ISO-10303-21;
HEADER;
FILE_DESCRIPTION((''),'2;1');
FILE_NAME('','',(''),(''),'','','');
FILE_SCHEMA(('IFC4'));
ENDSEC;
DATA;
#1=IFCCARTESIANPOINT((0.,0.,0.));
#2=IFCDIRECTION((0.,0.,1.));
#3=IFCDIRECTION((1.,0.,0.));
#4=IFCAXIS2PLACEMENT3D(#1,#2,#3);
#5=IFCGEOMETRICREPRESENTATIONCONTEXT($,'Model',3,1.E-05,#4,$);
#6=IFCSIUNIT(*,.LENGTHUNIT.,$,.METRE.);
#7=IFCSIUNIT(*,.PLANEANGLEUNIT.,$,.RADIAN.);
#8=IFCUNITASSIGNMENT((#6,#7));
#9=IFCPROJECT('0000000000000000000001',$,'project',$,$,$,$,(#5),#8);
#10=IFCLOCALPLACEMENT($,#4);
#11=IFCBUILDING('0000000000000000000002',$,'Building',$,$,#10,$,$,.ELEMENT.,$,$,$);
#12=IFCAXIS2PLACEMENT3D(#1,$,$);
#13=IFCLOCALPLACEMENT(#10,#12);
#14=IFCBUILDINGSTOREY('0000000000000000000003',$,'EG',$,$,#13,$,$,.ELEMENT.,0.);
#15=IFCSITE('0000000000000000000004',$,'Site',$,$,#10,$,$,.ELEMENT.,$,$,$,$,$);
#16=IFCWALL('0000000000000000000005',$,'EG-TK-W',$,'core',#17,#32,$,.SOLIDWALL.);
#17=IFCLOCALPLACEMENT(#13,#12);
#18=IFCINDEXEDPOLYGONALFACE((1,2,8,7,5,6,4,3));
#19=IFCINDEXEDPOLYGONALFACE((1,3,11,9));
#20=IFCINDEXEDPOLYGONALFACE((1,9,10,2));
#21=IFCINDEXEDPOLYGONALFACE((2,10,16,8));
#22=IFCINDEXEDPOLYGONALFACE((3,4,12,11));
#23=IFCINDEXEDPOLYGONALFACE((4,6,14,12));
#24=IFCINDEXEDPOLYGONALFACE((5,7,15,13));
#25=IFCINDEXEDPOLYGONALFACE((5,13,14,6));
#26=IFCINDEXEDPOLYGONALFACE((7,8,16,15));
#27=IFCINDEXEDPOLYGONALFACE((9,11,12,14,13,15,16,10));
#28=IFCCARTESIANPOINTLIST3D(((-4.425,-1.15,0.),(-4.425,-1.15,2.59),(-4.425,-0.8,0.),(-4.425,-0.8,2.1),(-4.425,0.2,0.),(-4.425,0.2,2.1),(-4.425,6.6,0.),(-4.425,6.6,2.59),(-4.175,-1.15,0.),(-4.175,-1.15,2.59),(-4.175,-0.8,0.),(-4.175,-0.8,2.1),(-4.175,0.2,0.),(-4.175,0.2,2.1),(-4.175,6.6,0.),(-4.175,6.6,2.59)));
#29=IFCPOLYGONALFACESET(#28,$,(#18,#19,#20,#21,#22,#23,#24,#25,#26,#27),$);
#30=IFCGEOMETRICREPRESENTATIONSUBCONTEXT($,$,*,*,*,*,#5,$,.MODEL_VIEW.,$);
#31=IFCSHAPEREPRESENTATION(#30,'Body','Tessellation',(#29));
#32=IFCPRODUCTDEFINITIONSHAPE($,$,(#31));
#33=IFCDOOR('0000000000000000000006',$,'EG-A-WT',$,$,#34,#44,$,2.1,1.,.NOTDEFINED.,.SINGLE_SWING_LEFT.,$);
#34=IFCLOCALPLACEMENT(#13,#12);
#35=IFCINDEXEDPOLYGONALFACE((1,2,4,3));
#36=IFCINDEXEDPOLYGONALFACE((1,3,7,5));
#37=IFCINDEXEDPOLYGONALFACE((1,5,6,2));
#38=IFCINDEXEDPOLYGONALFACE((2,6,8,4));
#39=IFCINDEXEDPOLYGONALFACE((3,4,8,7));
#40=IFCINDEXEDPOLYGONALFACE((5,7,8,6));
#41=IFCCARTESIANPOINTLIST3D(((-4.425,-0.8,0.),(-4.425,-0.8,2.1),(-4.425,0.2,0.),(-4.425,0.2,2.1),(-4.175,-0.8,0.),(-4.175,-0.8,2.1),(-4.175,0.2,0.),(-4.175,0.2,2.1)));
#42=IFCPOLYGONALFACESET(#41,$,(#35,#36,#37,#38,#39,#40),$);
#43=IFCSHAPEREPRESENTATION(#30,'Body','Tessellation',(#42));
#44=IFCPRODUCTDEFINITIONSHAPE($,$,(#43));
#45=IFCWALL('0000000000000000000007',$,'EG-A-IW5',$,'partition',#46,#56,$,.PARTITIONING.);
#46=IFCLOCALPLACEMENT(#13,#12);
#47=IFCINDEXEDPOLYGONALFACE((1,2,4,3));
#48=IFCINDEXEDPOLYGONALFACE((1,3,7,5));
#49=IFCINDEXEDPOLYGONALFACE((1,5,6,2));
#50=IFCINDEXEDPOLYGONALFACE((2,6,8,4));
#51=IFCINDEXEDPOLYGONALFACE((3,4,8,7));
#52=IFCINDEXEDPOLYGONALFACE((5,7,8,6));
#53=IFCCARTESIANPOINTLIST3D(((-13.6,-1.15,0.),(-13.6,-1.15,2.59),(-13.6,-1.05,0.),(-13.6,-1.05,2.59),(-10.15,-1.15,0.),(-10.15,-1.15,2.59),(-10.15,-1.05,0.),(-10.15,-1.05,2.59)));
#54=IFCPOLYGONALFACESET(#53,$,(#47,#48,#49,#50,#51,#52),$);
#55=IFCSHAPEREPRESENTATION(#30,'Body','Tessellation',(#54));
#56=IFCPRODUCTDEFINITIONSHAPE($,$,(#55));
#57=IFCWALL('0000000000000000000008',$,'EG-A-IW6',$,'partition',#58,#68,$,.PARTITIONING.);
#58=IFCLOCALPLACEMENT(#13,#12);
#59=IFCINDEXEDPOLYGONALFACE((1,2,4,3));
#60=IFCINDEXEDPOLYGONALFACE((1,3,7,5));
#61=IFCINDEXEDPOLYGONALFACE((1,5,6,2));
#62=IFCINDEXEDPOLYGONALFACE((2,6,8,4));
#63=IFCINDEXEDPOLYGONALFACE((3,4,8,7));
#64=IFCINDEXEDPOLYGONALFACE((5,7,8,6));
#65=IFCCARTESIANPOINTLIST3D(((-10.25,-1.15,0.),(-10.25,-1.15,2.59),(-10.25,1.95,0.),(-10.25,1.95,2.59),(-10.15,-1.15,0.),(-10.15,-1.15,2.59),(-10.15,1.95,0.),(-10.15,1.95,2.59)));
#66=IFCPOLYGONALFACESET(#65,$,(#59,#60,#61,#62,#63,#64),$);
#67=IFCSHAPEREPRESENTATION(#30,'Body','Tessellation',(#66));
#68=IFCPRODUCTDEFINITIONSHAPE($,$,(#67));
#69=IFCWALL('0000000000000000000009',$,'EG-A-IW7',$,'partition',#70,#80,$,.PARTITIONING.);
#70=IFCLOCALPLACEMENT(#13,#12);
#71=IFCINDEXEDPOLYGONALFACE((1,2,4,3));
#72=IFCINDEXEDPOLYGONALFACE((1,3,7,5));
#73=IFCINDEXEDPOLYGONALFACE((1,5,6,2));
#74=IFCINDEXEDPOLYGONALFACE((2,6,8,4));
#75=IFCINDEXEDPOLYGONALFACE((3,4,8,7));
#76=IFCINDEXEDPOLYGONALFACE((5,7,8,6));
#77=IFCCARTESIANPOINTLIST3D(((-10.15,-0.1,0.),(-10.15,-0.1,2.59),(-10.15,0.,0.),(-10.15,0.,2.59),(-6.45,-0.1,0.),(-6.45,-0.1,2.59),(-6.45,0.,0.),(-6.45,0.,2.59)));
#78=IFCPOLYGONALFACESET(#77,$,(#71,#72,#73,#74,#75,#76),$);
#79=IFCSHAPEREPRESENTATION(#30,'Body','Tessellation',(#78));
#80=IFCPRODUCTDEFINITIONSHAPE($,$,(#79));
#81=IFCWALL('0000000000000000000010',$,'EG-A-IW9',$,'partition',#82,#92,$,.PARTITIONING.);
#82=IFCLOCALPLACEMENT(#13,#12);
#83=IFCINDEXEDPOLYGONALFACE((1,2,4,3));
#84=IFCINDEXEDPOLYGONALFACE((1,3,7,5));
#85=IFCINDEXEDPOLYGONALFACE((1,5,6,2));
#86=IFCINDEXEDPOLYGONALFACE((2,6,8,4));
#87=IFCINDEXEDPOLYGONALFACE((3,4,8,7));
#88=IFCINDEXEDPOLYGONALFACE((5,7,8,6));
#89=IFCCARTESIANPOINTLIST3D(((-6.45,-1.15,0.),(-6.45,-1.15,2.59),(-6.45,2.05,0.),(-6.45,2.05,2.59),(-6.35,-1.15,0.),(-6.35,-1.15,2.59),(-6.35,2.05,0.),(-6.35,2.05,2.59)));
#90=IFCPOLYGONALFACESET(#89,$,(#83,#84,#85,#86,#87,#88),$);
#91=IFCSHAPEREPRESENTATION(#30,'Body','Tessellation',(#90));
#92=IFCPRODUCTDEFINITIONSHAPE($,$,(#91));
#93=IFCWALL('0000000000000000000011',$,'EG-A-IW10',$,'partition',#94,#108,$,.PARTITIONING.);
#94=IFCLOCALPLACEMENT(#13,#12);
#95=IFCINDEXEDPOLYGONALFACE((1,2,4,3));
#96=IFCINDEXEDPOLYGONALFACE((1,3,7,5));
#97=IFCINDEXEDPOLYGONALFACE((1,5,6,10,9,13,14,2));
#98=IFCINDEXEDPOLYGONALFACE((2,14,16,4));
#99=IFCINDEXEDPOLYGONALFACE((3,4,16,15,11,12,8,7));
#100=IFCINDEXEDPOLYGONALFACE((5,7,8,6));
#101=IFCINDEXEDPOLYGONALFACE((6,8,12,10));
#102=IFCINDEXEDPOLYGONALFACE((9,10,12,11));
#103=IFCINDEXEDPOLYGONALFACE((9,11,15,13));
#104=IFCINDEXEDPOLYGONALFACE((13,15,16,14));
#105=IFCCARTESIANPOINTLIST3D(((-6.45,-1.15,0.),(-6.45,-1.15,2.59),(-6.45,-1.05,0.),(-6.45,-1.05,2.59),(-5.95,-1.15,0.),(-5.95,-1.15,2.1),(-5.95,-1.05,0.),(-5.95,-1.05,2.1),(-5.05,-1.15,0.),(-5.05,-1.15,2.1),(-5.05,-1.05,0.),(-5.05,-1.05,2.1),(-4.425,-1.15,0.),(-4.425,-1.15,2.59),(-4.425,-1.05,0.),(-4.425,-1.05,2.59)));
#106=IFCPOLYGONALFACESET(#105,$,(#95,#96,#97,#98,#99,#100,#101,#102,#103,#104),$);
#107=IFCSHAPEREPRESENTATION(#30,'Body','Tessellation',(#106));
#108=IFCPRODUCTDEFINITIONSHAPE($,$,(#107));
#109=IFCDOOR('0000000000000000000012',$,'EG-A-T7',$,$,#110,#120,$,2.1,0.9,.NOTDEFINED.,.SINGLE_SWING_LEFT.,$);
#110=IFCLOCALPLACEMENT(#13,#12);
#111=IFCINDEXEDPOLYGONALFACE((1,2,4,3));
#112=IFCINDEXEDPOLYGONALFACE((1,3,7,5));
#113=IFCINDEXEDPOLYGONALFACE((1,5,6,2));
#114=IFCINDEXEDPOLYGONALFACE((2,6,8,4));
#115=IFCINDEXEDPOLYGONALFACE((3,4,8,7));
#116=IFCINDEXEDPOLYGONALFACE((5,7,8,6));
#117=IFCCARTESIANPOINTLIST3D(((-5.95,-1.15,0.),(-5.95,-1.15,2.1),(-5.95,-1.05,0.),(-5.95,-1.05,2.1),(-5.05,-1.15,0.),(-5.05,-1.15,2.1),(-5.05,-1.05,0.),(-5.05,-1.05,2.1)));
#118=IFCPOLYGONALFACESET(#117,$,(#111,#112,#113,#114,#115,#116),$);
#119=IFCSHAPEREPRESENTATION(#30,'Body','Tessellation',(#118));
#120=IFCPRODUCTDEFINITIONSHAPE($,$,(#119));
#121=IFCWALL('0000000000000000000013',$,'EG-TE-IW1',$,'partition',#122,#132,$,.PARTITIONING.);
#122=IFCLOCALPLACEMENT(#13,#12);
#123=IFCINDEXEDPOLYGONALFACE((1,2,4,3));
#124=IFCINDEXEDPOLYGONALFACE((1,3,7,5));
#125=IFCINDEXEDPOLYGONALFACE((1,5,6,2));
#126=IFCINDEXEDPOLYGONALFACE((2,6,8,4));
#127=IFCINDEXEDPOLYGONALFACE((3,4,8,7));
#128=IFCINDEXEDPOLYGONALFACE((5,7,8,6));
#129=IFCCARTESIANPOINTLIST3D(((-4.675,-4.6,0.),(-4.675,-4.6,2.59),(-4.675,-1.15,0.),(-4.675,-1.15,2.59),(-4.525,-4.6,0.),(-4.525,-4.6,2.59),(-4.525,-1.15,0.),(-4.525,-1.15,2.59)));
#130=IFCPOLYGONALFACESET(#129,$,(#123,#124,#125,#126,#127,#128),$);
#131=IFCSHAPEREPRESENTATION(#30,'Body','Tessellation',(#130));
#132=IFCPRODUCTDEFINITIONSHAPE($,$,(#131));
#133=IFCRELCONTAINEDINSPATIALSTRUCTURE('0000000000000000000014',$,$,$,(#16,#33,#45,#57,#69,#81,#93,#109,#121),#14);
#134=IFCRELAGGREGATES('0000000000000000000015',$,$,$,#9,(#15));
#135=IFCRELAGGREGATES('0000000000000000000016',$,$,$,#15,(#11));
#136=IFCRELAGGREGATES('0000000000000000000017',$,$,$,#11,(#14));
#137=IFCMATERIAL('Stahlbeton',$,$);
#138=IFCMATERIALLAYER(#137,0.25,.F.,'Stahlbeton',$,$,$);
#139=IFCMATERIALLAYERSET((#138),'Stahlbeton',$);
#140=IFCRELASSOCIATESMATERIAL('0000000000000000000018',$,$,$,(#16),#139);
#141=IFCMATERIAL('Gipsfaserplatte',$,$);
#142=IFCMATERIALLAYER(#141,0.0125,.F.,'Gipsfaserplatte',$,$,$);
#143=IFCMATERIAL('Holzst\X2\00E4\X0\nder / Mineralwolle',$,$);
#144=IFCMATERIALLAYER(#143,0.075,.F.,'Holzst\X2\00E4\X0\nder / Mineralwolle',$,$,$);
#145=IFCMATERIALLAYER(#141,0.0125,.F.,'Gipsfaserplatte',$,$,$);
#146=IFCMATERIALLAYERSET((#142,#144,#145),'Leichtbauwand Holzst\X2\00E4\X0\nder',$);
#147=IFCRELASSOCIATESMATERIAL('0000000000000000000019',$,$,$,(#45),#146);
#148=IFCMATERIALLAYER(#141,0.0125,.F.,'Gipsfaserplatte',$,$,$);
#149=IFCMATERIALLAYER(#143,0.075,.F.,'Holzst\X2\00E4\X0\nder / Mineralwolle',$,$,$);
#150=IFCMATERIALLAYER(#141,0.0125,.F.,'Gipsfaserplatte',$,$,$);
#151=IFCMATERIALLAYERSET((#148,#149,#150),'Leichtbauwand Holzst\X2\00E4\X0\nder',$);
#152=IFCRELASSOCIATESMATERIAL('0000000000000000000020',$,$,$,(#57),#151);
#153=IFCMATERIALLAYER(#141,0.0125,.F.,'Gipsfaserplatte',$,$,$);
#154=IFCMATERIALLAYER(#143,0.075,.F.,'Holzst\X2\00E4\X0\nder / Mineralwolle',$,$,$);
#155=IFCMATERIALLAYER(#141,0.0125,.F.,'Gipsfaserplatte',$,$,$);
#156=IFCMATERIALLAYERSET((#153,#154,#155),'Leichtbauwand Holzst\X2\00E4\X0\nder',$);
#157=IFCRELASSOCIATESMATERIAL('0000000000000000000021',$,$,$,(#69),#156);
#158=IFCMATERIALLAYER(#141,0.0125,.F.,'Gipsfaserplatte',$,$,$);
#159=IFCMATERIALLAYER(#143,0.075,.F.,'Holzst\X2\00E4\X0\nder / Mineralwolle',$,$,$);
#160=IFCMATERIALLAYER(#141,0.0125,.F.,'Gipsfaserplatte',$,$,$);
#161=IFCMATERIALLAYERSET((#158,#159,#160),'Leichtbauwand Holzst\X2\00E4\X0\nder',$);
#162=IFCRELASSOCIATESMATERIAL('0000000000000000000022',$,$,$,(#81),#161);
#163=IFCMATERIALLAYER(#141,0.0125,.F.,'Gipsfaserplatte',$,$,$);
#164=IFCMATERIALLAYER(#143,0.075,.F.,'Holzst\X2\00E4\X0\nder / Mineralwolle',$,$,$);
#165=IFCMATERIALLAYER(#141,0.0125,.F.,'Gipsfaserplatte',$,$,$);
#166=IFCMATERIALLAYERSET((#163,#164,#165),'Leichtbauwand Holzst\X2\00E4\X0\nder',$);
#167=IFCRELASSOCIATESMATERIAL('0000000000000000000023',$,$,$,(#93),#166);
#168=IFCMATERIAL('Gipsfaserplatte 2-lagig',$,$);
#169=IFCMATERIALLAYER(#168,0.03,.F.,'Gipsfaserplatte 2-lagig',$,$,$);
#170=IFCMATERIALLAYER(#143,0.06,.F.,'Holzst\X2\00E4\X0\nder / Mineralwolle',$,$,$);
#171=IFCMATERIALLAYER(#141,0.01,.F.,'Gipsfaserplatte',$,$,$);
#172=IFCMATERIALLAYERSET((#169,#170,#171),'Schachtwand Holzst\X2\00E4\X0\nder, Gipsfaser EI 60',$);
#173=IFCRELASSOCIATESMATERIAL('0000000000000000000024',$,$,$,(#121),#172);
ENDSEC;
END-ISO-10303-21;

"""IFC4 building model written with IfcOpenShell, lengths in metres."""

from ifc_helpers import new_model, si_unit, frame, frame_2d, origin, origin_with_axes, place, context, subcontext, project, spatial, rectangle, extrude, material, layer, layer_set, element, fill, save


model = new_model("IFC4")

# Units and contexts
model_context = context("Model", 3, precision=1e-05, world=origin_with_axes())
sub_context = subcontext(model_context, None, None, "MODEL_VIEW")
ifc_project = project(units=[si_unit("LENGTHUNIT", "METRE"), si_unit("PLANEANGLEUNIT", "RADIAN")], contexts=[model_context])

# Site, building, storey
placement = place(None, origin_with_axes())
site = spatial("IfcSite", under=ifc_project, at=placement, Name="Site", CompositionType="ELEMENT")
building = spatial("IfcBuilding", under=site, at=placement, Name="Building", CompositionType="ELEMENT")
storey_placement = place(placement, origin())
storey = spatial("IfcBuildingStorey", under=building, at=storey_placement, Name="EG", CompositionType="ELEMENT", Elevation=0.0)

# Shared definitions
ifc_material_1 = material(Name="Gipsfaserplatte")

# Wall, opening, door
ifc_material_2 = material(Name="Stahlbeton")
ifc_layer_1 = layer(ifc_material_2, 0.25, ventilated=False, Name="Stahlbeton")
ifc_layer_set_1 = layer_set([ifc_layer_1], Name="Stahlbeton")
wall_1_placement = place(storey_placement, frame((-4.3, -1.15, 0.0), z_axis=(0.0, 0.0, 1.0), x_axis=(0.0, 1.0, 0.0)))
wall_1 = element("IfcWall", 1, at=wall_1_placement, inside=storey, material=ifc_layer_set_1, Name="EG-TK-W", ObjectType="core", PredefinedType="SOLIDWALL", context=sub_context, shape_type="SweptSolid", body=[
    extrude(rectangle(XDim=7.75, YDim=0.25, at=frame_2d((3.875, 0.0))), origin(), (0.0, 0.0, 1.0), 2.59),
])
opening_1_placement = place(wall_1_placement, frame((0.85, 0.175, 0.0), z_axis=(0.0, -1.0, 0.0), x_axis=(1.0, 0.0, 0.0)))
opening_1 = element("IfcOpeningElement", 2, at=opening_1_placement, cuts=wall_1, PredefinedType="OPENING", context=sub_context, shape_type="SweptSolid", body=[
    extrude(rectangle(XDim=1.0, YDim=2.1, at=frame_2d((0.0, 1.05))), origin(), (0.0, 0.0, 1.0), 0.35),
])
door_1_placement = place(wall_1_placement, frame((0.85, 0.125, 0.0), z_axis=(0.0, -1.0, 0.0), x_axis=(1.0, 0.0, 0.0)))
door_1 = element("IfcDoor", 3, at=door_1_placement, inside=storey, Name="EG-A-WT", OperationType="SINGLE_SWING_LEFT", OverallHeight=2.1, OverallWidth=1.0, PredefinedType="NOTDEFINED", context=sub_context, shape_type="SweptSolid", body=[
    extrude(rectangle(XDim=1.0, YDim=2.1, at=frame_2d((0.0, 1.05))), origin(), (0.0, 0.0, 1.0), 0.25),
])
fill(opening_1, door_1)

# Walls
ifc_layer_2 = layer(ifc_material_1, 0.0125, ventilated=False, Name="Gipsfaserplatte")
ifc_material_3 = material(Name="Holzständer / Mineralwolle")
ifc_layer_3 = layer(ifc_material_3, 0.075, ventilated=False, Name="Holzständer / Mineralwolle")
ifc_layer_4 = layer(ifc_material_1, 0.0125, ventilated=False, Name="Gipsfaserplatte")
ifc_layer_set_2 = layer_set([ifc_layer_2, ifc_layer_3, ifc_layer_4], Name="Leichtbauwand Holzständer")
wall_2_placement = place(storey_placement, frame((-13.6, -1.1, 0.0), z_axis=(0.0, 0.0, 1.0), x_axis=(1.0, 0.0, 0.0)))
element("IfcWall", 4, at=wall_2_placement, inside=storey, material=ifc_layer_set_2, Name="EG-A-IW5", ObjectType="partition", PredefinedType="PARTITIONING", context=sub_context, shape_type="SweptSolid", body=[
    extrude(rectangle(XDim=3.45, YDim=0.1, at=frame_2d((1.725, 0.0))), origin(), (0.0, 0.0, 1.0), 2.59),
])
ifc_layer_5 = layer(ifc_material_1, 0.0125, ventilated=False, Name="Gipsfaserplatte")
ifc_layer_6 = layer(ifc_material_3, 0.075, ventilated=False, Name="Holzständer / Mineralwolle")
ifc_layer_7 = layer(ifc_material_1, 0.0125, ventilated=False, Name="Gipsfaserplatte")
ifc_layer_set_3 = layer_set([ifc_layer_5, ifc_layer_6, ifc_layer_7], Name="Leichtbauwand Holzständer")
wall_3_placement = place(storey_placement, frame((-10.2, -1.15, 0.0), z_axis=(0.0, 0.0, 1.0), x_axis=(0.0, 1.0, 0.0)))
element("IfcWall", 5, at=wall_3_placement, inside=storey, material=ifc_layer_set_3, Name="EG-A-IW6", ObjectType="partition", PredefinedType="PARTITIONING", context=sub_context, shape_type="SweptSolid", body=[
    extrude(rectangle(XDim=3.1, YDim=0.1, at=frame_2d((1.55, 0.0))), origin(), (0.0, 0.0, 1.0), 2.59),
])
ifc_layer_8 = layer(ifc_material_1, 0.0125, ventilated=False, Name="Gipsfaserplatte")
ifc_layer_9 = layer(ifc_material_3, 0.075, ventilated=False, Name="Holzständer / Mineralwolle")
ifc_layer_10 = layer(ifc_material_1, 0.0125, ventilated=False, Name="Gipsfaserplatte")
ifc_layer_set_4 = layer_set([ifc_layer_8, ifc_layer_9, ifc_layer_10], Name="Leichtbauwand Holzständer")
wall_4_placement = place(storey_placement, frame((-10.15, -0.05, 0.0), z_axis=(0.0, 0.0, 1.0), x_axis=(1.0, 0.0, 0.0)))
element("IfcWall", 6, at=wall_4_placement, inside=storey, material=ifc_layer_set_4, Name="EG-A-IW7", ObjectType="partition", PredefinedType="PARTITIONING", context=sub_context, shape_type="SweptSolid", body=[
    extrude(rectangle(XDim=3.7, YDim=0.1, at=frame_2d((1.85, 0.0))), origin(), (0.0, 0.0, 1.0), 2.59),
])
ifc_layer_11 = layer(ifc_material_1, 0.0125, ventilated=False, Name="Gipsfaserplatte")
ifc_layer_12 = layer(ifc_material_3, 0.075, ventilated=False, Name="Holzständer / Mineralwolle")
ifc_layer_13 = layer(ifc_material_1, 0.0125, ventilated=False, Name="Gipsfaserplatte")
ifc_layer_set_5 = layer_set([ifc_layer_11, ifc_layer_12, ifc_layer_13], Name="Leichtbauwand Holzständer")
wall_5_placement = place(storey_placement, frame((-6.4, -1.15, 0.0), z_axis=(0.0, 0.0, 1.0), x_axis=(0.0, 1.0, 0.0)))
element("IfcWall", 7, at=wall_5_placement, inside=storey, material=ifc_layer_set_5, Name="EG-A-IW9", ObjectType="partition", PredefinedType="PARTITIONING", context=sub_context, shape_type="SweptSolid", body=[
    extrude(rectangle(XDim=3.2, YDim=0.1, at=frame_2d((1.6, 0.0))), origin(), (0.0, 0.0, 1.0), 2.59),
])

# Wall, opening, door
ifc_layer_14 = layer(ifc_material_1, 0.0125, ventilated=False, Name="Gipsfaserplatte")
ifc_layer_15 = layer(ifc_material_3, 0.075, ventilated=False, Name="Holzständer / Mineralwolle")
ifc_layer_16 = layer(ifc_material_1, 0.0125, ventilated=False, Name="Gipsfaserplatte")
ifc_layer_set_6 = layer_set([ifc_layer_14, ifc_layer_15, ifc_layer_16], Name="Leichtbauwand Holzständer")
wall_6_placement = place(storey_placement, frame((-6.45, -1.1, 0.0), z_axis=(0.0, 0.0, 1.0), x_axis=(1.0, 0.0, 0.0)))
wall_6 = element("IfcWall", 8, at=wall_6_placement, inside=storey, material=ifc_layer_set_6, Name="EG-A-IW10", ObjectType="partition", PredefinedType="PARTITIONING", context=sub_context, shape_type="SweptSolid", body=[
    extrude(rectangle(XDim=2.025, YDim=0.1, at=frame_2d((1.0125, 0.0))), origin(), (0.0, 0.0, 1.0), 2.59),
])
opening_2_placement = place(wall_6_placement, frame((0.95, 0.1, 0.0), z_axis=(0.0, -1.0, 0.0), x_axis=(1.0, 0.0, 0.0)))
opening_2 = element("IfcOpeningElement", 9, at=opening_2_placement, cuts=wall_6, PredefinedType="OPENING", context=sub_context, shape_type="SweptSolid", body=[
    extrude(rectangle(XDim=0.9, YDim=2.1, at=frame_2d((0.0, 1.05))), origin(), (0.0, 0.0, 1.0), 0.2),
])
door_2_placement = place(wall_6_placement, frame((0.95, 0.05, 0.0), z_axis=(0.0, -1.0, 0.0), x_axis=(1.0, 0.0, 0.0)))
door_2 = element("IfcDoor", 10, at=door_2_placement, inside=storey, Name="EG-A-T7", OperationType="SINGLE_SWING_LEFT", OverallHeight=2.1, OverallWidth=0.9, PredefinedType="NOTDEFINED", context=sub_context, shape_type="SweptSolid", body=[
    extrude(rectangle(XDim=0.9, YDim=2.1, at=frame_2d((0.0, 1.05))), origin(), (0.0, 0.0, 1.0), 0.1),
])
fill(opening_2, door_2)

# Wall
ifc_material_4 = material(Name="Gipsfaserplatte 2-lagig")
ifc_layer_17 = layer(ifc_material_4, 0.03, ventilated=False, Name="Gipsfaserplatte 2-lagig")
ifc_layer_18 = layer(ifc_material_3, 0.06, ventilated=False, Name="Holzständer / Mineralwolle")
ifc_layer_19 = layer(ifc_material_1, 0.01, ventilated=False, Name="Gipsfaserplatte")
ifc_layer_set_7 = layer_set([ifc_layer_17, ifc_layer_18, ifc_layer_19], Name="Schachtwand Holzständer, Gipsfaser EI 60")
wall_7_placement = place(storey_placement, frame((-4.6, -4.6, 0.0), z_axis=(0.0, 0.0, 1.0), x_axis=(0.0, 1.0, 0.0)))
element("IfcWall", 11, at=wall_7_placement, inside=storey, material=ifc_layer_set_7, Name="EG-TE-IW1", ObjectType="partition", PredefinedType="PARTITIONING", context=sub_context, shape_type="SweptSolid", body=[
    extrude(rectangle(XDim=3.45, YDim=0.15, at=frame_2d((1.725, 0.0))), origin(), (0.0, 0.0, 1.0), 2.59),
])

save(model, "model.ifc")
